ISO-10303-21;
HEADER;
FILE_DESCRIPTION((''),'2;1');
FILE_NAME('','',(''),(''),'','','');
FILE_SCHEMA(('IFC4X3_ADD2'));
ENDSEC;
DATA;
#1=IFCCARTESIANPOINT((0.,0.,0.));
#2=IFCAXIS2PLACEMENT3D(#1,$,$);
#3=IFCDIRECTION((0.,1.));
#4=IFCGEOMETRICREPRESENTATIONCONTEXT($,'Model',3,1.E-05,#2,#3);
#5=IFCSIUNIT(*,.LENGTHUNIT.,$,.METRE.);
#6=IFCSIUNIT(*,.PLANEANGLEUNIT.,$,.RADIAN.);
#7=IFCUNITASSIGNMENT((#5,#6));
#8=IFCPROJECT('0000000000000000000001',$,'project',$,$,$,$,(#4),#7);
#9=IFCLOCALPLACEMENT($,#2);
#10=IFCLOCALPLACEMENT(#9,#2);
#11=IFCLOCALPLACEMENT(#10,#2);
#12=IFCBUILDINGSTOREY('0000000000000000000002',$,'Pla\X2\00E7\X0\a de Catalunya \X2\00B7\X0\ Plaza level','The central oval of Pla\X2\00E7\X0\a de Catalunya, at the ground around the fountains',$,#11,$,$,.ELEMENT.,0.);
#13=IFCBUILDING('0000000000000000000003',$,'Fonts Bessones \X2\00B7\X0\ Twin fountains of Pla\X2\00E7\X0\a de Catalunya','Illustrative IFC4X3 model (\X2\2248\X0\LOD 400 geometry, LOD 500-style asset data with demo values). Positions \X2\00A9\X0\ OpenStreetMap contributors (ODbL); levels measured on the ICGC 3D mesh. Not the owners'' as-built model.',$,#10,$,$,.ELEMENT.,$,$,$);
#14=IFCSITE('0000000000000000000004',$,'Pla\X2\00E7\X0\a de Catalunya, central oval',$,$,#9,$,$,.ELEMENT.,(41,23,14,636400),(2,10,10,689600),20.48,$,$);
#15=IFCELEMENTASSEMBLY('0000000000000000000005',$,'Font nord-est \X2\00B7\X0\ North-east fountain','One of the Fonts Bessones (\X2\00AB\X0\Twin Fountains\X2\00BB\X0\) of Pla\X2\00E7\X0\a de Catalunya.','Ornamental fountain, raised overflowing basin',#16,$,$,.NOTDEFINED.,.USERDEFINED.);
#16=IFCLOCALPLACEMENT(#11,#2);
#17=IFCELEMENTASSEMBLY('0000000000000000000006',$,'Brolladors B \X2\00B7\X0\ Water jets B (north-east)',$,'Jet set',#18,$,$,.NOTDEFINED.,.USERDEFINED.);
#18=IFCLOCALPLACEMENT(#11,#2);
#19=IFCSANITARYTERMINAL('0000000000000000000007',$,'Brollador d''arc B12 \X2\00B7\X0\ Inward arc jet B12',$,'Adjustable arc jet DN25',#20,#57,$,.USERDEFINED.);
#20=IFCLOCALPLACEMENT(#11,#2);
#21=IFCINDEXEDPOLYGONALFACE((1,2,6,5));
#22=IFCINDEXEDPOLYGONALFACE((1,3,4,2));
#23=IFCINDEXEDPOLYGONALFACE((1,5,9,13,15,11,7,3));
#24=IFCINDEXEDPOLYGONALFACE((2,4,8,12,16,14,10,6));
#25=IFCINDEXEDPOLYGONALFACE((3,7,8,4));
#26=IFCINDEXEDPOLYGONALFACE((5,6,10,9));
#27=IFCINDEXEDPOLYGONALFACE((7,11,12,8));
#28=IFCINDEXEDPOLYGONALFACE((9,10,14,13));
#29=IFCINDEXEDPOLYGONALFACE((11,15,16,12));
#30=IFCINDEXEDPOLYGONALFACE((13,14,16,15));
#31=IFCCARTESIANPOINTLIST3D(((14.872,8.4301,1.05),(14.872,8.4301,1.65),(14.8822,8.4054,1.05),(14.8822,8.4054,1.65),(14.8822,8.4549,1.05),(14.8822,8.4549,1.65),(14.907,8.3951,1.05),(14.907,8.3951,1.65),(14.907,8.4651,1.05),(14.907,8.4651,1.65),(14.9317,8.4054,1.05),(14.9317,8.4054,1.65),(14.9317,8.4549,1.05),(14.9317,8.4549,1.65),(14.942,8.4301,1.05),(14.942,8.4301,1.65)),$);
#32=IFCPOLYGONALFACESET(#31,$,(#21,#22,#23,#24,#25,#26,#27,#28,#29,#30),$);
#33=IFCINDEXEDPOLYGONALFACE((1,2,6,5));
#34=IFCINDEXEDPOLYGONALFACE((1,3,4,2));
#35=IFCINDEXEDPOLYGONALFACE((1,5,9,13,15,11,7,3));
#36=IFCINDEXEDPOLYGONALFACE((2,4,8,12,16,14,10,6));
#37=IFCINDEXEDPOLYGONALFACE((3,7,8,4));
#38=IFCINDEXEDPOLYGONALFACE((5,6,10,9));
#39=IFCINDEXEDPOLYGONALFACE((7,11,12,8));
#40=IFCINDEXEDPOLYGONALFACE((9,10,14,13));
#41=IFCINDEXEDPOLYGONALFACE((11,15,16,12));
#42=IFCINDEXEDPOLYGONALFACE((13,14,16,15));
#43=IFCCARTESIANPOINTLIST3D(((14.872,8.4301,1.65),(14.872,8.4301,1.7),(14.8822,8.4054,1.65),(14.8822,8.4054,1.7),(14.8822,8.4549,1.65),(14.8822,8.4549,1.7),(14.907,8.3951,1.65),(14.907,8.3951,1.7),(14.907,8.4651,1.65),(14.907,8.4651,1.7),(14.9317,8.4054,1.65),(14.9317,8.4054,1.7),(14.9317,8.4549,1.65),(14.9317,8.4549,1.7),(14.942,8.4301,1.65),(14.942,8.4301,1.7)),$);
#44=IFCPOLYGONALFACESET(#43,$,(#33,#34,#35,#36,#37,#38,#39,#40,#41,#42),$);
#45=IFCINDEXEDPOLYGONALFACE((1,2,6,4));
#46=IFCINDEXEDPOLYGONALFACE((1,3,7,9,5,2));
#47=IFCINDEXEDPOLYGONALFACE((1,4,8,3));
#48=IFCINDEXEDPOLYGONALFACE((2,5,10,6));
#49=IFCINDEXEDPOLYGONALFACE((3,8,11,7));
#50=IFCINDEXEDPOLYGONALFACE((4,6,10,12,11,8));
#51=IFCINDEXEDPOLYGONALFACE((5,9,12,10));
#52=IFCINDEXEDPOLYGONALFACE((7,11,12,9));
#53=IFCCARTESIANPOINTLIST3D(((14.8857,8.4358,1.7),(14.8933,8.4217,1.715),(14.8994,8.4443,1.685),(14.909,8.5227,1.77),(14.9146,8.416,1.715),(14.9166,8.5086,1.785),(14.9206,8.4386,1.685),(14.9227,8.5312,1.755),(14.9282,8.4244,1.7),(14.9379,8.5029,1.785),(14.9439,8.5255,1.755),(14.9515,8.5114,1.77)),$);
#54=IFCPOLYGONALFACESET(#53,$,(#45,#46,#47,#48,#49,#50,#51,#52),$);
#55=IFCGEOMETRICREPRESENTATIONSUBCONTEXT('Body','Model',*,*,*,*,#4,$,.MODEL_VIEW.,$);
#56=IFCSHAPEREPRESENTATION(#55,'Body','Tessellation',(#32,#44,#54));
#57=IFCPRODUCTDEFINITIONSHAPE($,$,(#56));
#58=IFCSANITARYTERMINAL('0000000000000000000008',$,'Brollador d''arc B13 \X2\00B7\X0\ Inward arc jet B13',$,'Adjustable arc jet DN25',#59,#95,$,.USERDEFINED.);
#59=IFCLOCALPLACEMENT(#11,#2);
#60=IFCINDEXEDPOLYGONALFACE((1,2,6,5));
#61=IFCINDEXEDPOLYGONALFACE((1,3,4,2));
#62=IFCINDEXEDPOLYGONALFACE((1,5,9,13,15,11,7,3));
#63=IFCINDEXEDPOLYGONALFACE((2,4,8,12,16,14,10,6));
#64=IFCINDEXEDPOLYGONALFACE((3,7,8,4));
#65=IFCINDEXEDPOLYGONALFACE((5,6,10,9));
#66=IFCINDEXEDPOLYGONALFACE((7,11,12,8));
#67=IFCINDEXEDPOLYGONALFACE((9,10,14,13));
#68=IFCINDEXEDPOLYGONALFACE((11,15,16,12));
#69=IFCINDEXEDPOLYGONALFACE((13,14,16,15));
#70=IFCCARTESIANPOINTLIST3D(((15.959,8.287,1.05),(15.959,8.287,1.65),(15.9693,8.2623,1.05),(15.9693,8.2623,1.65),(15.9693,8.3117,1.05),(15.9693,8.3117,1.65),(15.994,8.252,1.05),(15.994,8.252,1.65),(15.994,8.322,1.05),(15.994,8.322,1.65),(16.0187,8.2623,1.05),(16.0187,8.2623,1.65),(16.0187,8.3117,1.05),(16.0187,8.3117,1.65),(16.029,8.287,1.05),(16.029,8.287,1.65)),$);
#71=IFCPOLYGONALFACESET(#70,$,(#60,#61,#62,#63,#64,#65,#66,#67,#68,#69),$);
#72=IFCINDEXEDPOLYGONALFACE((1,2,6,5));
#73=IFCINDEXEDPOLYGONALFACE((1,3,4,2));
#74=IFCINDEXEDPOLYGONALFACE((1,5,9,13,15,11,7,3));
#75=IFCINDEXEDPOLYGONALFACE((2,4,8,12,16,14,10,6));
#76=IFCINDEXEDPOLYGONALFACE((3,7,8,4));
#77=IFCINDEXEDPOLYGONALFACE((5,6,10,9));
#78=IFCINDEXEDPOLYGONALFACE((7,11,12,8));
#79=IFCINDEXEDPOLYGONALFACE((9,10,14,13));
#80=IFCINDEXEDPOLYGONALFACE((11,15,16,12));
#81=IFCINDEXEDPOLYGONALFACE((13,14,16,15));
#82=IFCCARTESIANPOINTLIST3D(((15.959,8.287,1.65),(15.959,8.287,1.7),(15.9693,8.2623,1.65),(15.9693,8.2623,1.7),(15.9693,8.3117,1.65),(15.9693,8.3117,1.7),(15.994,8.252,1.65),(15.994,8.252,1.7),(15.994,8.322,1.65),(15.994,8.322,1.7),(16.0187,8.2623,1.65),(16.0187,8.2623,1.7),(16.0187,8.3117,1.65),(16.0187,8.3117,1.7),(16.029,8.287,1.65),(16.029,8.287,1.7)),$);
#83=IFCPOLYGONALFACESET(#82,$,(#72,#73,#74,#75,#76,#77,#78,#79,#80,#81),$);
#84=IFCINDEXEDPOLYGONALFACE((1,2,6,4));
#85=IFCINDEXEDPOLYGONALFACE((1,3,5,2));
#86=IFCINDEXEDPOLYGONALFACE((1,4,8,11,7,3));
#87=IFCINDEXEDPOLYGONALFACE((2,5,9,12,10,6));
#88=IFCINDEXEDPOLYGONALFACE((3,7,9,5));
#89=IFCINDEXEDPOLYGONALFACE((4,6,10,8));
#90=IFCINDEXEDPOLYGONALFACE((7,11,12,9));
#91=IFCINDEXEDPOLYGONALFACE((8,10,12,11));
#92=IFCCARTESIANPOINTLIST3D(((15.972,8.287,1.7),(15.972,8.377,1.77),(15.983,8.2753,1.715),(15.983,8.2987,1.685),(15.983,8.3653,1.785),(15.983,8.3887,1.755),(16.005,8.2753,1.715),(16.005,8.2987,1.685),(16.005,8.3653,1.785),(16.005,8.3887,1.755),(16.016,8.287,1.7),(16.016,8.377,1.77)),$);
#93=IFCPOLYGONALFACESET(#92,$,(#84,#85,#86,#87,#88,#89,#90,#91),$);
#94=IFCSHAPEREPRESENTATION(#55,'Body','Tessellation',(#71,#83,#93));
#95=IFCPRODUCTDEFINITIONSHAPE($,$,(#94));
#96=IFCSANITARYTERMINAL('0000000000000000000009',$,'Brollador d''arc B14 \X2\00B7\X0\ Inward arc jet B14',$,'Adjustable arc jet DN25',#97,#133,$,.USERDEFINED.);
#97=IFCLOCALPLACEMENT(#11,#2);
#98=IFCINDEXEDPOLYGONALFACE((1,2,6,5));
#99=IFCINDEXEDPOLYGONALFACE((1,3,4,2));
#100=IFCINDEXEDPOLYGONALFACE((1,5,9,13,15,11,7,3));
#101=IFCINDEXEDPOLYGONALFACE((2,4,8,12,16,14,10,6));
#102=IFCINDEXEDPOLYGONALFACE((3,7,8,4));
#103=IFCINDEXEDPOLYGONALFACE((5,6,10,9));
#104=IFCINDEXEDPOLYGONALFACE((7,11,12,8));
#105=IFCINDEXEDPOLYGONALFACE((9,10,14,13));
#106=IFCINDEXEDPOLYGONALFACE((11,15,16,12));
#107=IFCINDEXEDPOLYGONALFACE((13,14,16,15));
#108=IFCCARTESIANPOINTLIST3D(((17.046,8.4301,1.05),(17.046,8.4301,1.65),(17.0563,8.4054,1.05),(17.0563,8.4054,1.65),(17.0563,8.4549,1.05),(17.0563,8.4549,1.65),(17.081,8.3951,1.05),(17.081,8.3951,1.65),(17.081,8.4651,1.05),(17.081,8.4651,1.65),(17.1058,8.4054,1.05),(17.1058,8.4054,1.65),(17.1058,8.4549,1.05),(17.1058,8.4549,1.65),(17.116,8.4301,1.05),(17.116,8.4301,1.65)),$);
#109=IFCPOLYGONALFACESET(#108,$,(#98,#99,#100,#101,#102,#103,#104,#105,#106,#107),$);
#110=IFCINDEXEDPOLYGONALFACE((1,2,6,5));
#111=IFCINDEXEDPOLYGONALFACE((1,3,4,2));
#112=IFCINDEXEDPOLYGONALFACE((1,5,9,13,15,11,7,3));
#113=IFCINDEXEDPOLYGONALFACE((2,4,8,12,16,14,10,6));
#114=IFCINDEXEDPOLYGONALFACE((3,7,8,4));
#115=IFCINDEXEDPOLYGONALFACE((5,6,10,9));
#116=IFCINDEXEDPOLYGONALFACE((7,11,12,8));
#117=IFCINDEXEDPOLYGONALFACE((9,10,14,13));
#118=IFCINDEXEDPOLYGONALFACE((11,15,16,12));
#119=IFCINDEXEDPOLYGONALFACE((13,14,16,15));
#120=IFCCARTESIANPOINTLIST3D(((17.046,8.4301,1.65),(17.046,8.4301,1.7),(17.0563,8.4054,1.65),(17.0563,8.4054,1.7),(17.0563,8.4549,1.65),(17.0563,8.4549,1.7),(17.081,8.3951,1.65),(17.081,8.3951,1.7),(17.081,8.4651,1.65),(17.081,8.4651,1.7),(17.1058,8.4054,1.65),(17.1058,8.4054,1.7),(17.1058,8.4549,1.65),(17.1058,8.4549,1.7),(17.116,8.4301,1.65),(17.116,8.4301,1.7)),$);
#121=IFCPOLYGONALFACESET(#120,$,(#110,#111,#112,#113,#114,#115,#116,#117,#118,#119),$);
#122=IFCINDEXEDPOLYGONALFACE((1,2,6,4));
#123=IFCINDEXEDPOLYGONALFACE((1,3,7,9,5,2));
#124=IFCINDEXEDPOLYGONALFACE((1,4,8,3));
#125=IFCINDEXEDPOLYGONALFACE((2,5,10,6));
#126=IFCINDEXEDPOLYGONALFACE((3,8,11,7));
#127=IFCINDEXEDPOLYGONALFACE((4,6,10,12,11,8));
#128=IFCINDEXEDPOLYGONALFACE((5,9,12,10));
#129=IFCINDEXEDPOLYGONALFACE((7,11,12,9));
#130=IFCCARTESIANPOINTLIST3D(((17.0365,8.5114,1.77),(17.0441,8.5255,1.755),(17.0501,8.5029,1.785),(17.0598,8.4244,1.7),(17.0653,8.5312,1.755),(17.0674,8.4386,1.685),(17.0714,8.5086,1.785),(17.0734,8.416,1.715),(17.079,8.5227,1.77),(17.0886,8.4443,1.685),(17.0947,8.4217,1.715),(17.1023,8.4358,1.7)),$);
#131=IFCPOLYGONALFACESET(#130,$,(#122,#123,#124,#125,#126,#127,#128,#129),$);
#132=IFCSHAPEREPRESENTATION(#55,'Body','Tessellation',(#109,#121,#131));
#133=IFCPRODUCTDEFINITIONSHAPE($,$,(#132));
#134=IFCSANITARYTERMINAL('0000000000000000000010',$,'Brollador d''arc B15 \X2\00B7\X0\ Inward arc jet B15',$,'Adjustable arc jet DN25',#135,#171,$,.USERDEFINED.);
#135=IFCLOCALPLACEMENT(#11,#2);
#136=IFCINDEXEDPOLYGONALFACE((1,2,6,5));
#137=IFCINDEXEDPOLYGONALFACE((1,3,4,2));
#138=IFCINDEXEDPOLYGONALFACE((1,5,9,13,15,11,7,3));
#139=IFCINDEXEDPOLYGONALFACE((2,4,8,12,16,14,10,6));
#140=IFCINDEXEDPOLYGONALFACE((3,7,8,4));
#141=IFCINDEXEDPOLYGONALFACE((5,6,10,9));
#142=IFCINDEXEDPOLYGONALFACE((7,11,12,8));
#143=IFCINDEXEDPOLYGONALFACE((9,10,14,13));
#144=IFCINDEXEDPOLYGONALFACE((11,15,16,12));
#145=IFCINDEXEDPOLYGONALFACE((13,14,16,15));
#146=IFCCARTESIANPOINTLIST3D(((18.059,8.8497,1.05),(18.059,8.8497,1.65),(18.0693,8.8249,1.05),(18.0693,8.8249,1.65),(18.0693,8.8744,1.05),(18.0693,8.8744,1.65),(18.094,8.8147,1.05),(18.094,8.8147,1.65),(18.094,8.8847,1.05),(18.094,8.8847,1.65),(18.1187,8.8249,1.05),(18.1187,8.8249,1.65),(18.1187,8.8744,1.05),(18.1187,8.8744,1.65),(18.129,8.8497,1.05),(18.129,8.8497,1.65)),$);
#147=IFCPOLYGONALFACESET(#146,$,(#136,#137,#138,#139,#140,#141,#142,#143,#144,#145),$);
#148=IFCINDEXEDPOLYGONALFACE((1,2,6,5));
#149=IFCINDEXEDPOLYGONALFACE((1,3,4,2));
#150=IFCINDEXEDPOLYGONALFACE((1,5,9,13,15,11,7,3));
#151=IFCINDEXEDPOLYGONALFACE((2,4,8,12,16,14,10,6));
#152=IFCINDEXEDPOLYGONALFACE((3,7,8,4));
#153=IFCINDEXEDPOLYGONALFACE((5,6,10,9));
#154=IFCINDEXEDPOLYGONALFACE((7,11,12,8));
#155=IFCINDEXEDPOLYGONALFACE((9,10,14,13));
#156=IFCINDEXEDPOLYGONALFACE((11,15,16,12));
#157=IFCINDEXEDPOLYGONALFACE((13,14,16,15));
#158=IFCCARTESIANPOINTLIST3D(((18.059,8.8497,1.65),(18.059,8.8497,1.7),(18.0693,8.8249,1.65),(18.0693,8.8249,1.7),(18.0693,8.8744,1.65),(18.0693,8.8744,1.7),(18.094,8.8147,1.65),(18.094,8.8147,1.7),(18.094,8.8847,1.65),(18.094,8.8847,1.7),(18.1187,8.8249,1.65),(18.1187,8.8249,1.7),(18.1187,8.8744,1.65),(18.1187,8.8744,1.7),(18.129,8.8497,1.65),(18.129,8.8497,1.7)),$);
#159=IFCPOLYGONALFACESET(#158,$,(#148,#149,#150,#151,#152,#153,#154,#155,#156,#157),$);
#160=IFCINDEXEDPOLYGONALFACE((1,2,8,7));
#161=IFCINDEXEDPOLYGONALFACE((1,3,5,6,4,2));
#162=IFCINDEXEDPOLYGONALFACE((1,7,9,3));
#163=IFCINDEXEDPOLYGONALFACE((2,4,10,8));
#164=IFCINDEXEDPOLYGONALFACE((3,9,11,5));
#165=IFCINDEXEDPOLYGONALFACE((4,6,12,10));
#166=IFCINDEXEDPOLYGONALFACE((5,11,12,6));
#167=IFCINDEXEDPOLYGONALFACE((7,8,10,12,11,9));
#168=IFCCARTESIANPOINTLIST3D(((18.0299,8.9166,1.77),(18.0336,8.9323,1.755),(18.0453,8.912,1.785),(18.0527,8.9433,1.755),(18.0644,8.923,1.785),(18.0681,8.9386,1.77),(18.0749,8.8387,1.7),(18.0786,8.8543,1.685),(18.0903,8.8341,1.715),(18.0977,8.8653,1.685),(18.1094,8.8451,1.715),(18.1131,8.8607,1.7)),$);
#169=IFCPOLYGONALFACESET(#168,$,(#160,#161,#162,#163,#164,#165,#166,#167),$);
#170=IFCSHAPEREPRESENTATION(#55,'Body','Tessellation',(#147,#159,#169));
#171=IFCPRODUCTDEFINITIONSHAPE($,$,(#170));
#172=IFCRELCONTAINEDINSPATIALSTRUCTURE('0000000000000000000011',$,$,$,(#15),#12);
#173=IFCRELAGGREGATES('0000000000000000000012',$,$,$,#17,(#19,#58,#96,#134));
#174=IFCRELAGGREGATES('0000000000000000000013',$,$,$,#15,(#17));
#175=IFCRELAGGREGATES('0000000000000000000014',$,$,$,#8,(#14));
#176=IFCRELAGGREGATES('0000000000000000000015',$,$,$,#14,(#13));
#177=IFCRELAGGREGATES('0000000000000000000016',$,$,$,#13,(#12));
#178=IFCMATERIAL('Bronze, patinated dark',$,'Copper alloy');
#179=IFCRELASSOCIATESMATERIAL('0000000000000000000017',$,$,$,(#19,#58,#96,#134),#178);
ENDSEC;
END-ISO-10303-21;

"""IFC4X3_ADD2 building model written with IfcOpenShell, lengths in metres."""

from ifc_helpers import new_model, si_unit, direction, frame, origin, place, context, subcontext, project, spatial, polyline, outline, extrude, material, element, aggregate, save


model = new_model("IFC4X3_ADD2")

# Units and contexts
model_context = context("Model", 3, precision=1e-05, world=origin(), true_north=direction((0.0, 1.0)))
body_context = subcontext(model_context, "Body", "Model", "MODEL_VIEW")
ifc_project = project(units=[si_unit("LENGTHUNIT", "METRE"), si_unit("PLANEANGLEUNIT", "RADIAN")], contexts=[model_context])

# Site, building, storey
site_placement = place(None, origin())
site = spatial("IfcSite", under=ifc_project, at=site_placement, Name="Plaça de Catalunya, central oval", CompositionType="ELEMENT", RefLatitude=(41, 23, 14, 636400), RefLongitude=(2, 10, 10, 689600), RefElevation=20.48)
building_placement = place(site_placement, origin())
building = spatial("IfcBuilding", under=site, at=building_placement, Name="Fonts Bessones · Twin fountains of Plaça de Catalunya", Description="Illustrative IFC4X3 model (≈LOD 400 geometry, LOD 500-style asset data with demo values). Positions © OpenStreetMap contributors (ODbL); levels measured on the ICGC 3D mesh. Not the owners' as-built model.", CompositionType="ELEMENT")
storey_placement = place(building_placement, origin())
storey = spatial("IfcBuildingStorey", under=building, at=storey_placement, Name="Plaça de Catalunya · Plaza level", Description="The central oval of Plaça de Catalunya, at the ground around the fountains", CompositionType="ELEMENT", Elevation=0.0)

# Element assemblies, sanitary terminals
assembly_1_placement = place(building_placement, origin())
assembly_1 = element("IfcElementAssembly", 1, at=assembly_1_placement, inside=storey, Name="Font nord-est · North-east fountain", Description="One of the Fonts Bessones («Twin Fountains») of Plaça de Catalunya.", ObjectType="Ornamental fountain, raised overflowing basin", AssemblyPlace="NOTDEFINED", PredefinedType="USERDEFINED")
assembly_2_placement = place(building_placement, origin())
assembly_2 = element("IfcElementAssembly", 2, at=assembly_2_placement, Name="Brolladors B · Water jets B (north-east)", ObjectType="Jet set", AssemblyPlace="NOTDEFINED", PredefinedType="USERDEFINED")
ifc_material_1 = material(Name="Bronze, patinated dark", Category="Copper alloy")
sanitary_terminal_1_placement = place(building_placement, origin())
sanitary_terminal_1 = element("IfcSanitaryTerminal", 3, at=sanitary_terminal_1_placement, material=ifc_material_1, Name="Brollador d'arc B12 · Inward arc jet B12", ObjectType="Adjustable arc jet DN25", PredefinedType="USERDEFINED", context=body_context, shape_type="SweptSolid", body=[
    extrude(outline(polyline([(14.942, 8.4301), (14.9317, 8.4549), (14.907, 8.4651), (14.8822, 8.4549), (14.872, 8.4301), (14.8822, 8.4054), (14.907, 8.3951), (14.9317, 8.4054), (14.942, 8.4301)])), frame((0.0, 0.0, 1.05)), (0.0, 0.0, 1.0), 0.6),
    extrude(outline(polyline([(14.942, 8.4301), (14.9317, 8.4549), (14.907, 8.4651), (14.8822, 8.4549), (14.872, 8.4301), (14.8822, 8.4054), (14.907, 8.3951), (14.9317, 8.4054), (14.942, 8.4301)])), frame((0.0, 0.0, 1.65)), (0.0, 0.0, 1.0), 0.05),
    extrude(outline(polyline([(0.022, 0.0), (0.011, 0.0191), (-0.011, 0.0191), (-0.022, 0.0), (-0.011, -0.0191), (0.011, -0.0191), (0.022, 0.0)])), frame((14.907, 8.4301, 1.7), z_axis=(0.204299, 0.762456, 0.613941), x_axis=(0.965926, -0.258819, 0.0)), (0.0, 0.0, 1.0), 0.114),
])
sanitary_terminal_2_placement = place(building_placement, origin())
sanitary_terminal_2 = element("IfcSanitaryTerminal", 4, at=sanitary_terminal_2_placement, material=ifc_material_1, Name="Brollador d'arc B13 · Inward arc jet B13", ObjectType="Adjustable arc jet DN25", PredefinedType="USERDEFINED", context=body_context, shape_type="SweptSolid", body=[
    extrude(outline(polyline([(16.029, 8.287), (16.0187, 8.3117), (15.994, 8.322), (15.9693, 8.3117), (15.959, 8.287), (15.9693, 8.2623), (15.994, 8.252), (16.0187, 8.2623), (16.029, 8.287)])), frame((0.0, 0.0, 1.05)), (0.0, 0.0, 1.0), 0.6),
    extrude(outline(polyline([(16.029, 8.287), (16.0187, 8.3117), (15.994, 8.322), (15.9693, 8.3117), (15.959, 8.287), (15.9693, 8.2623), (15.994, 8.252), (16.0187, 8.2623), (16.029, 8.287)])), frame((0.0, 0.0, 1.65)), (0.0, 0.0, 1.0), 0.05),
    extrude(outline(polyline([(0.022, 0.0), (0.011, 0.0191), (-0.011, 0.0191), (-0.022, 0.0), (-0.011, -0.0191), (0.011, -0.0191), (0.022, 0.0)])), frame((15.994, 8.287, 1.7), z_axis=(0.0, 0.789352, 0.613941), x_axis=(1.0, 0.0, 0.0)), (0.0, 0.0, 1.0), 0.114),
])
sanitary_terminal_3_placement = place(building_placement, origin())
sanitary_terminal_3 = element("IfcSanitaryTerminal", 5, at=sanitary_terminal_3_placement, material=ifc_material_1, Name="Brollador d'arc B14 · Inward arc jet B14", ObjectType="Adjustable arc jet DN25", PredefinedType="USERDEFINED", context=body_context, shape_type="SweptSolid", body=[
    extrude(outline(polyline([(17.116, 8.4301), (17.1058, 8.4549), (17.081, 8.4651), (17.0563, 8.4549), (17.046, 8.4301), (17.0563, 8.4054), (17.081, 8.3951), (17.1058, 8.4054), (17.116, 8.4301)])), frame((0.0, 0.0, 1.05)), (0.0, 0.0, 1.0), 0.6),
    extrude(outline(polyline([(17.116, 8.4301), (17.1058, 8.4549), (17.081, 8.4651), (17.0563, 8.4549), (17.046, 8.4301), (17.0563, 8.4054), (17.081, 8.3951), (17.1058, 8.4054), (17.116, 8.4301)])), frame((0.0, 0.0, 1.65)), (0.0, 0.0, 1.0), 0.05),
    extrude(outline(polyline([(0.022, 0.0), (0.011, 0.0191), (-0.011, 0.0191), (-0.022, 0.0), (-0.011, -0.0191), (0.011, -0.0191), (0.022, 0.0)])), frame((17.081, 8.4301, 1.7), z_axis=(-0.204299, 0.762456, 0.613941), x_axis=(0.965926, 0.258819, 0.0)), (0.0, 0.0, 1.0), 0.114),
])
sanitary_terminal_4_placement = place(building_placement, origin())
sanitary_terminal_4 = element("IfcSanitaryTerminal", 6, at=sanitary_terminal_4_placement, material=ifc_material_1, Name="Brollador d'arc B15 · Inward arc jet B15", ObjectType="Adjustable arc jet DN25", PredefinedType="USERDEFINED", context=body_context, shape_type="SweptSolid", body=[
    extrude(outline(polyline([(18.129, 8.8497), (18.1187, 8.8744), (18.094, 8.8847), (18.0693, 8.8744), (18.059, 8.8497), (18.0693, 8.8249), (18.094, 8.8147), (18.1187, 8.8249), (18.129, 8.8497)])), frame((0.0, 0.0, 1.05)), (0.0, 0.0, 1.0), 0.6),
    extrude(outline(polyline([(18.129, 8.8497), (18.1187, 8.8744), (18.094, 8.8847), (18.0693, 8.8744), (18.059, 8.8497), (18.0693, 8.8249), (18.094, 8.8147), (18.1187, 8.8249), (18.129, 8.8497)])), frame((0.0, 0.0, 1.65)), (0.0, 0.0, 1.0), 0.05),
    extrude(outline(polyline([(0.022, 0.0), (0.011, 0.0191), (-0.011, 0.0191), (-0.022, 0.0), (-0.011, -0.0191), (0.011, -0.0191), (0.022, 0.0)])), frame((18.094, 8.8497, 1.7), z_axis=(-0.394676, 0.683599, 0.613941), x_axis=(0.866025, 0.5, 0.0)), (0.0, 0.0, 1.0), 0.114),
])
aggregate(assembly_2, [sanitary_terminal_1, sanitary_terminal_2, sanitary_terminal_3, sanitary_terminal_4])
aggregate(assembly_1, [assembly_2])

save(model, "model.ifc")
